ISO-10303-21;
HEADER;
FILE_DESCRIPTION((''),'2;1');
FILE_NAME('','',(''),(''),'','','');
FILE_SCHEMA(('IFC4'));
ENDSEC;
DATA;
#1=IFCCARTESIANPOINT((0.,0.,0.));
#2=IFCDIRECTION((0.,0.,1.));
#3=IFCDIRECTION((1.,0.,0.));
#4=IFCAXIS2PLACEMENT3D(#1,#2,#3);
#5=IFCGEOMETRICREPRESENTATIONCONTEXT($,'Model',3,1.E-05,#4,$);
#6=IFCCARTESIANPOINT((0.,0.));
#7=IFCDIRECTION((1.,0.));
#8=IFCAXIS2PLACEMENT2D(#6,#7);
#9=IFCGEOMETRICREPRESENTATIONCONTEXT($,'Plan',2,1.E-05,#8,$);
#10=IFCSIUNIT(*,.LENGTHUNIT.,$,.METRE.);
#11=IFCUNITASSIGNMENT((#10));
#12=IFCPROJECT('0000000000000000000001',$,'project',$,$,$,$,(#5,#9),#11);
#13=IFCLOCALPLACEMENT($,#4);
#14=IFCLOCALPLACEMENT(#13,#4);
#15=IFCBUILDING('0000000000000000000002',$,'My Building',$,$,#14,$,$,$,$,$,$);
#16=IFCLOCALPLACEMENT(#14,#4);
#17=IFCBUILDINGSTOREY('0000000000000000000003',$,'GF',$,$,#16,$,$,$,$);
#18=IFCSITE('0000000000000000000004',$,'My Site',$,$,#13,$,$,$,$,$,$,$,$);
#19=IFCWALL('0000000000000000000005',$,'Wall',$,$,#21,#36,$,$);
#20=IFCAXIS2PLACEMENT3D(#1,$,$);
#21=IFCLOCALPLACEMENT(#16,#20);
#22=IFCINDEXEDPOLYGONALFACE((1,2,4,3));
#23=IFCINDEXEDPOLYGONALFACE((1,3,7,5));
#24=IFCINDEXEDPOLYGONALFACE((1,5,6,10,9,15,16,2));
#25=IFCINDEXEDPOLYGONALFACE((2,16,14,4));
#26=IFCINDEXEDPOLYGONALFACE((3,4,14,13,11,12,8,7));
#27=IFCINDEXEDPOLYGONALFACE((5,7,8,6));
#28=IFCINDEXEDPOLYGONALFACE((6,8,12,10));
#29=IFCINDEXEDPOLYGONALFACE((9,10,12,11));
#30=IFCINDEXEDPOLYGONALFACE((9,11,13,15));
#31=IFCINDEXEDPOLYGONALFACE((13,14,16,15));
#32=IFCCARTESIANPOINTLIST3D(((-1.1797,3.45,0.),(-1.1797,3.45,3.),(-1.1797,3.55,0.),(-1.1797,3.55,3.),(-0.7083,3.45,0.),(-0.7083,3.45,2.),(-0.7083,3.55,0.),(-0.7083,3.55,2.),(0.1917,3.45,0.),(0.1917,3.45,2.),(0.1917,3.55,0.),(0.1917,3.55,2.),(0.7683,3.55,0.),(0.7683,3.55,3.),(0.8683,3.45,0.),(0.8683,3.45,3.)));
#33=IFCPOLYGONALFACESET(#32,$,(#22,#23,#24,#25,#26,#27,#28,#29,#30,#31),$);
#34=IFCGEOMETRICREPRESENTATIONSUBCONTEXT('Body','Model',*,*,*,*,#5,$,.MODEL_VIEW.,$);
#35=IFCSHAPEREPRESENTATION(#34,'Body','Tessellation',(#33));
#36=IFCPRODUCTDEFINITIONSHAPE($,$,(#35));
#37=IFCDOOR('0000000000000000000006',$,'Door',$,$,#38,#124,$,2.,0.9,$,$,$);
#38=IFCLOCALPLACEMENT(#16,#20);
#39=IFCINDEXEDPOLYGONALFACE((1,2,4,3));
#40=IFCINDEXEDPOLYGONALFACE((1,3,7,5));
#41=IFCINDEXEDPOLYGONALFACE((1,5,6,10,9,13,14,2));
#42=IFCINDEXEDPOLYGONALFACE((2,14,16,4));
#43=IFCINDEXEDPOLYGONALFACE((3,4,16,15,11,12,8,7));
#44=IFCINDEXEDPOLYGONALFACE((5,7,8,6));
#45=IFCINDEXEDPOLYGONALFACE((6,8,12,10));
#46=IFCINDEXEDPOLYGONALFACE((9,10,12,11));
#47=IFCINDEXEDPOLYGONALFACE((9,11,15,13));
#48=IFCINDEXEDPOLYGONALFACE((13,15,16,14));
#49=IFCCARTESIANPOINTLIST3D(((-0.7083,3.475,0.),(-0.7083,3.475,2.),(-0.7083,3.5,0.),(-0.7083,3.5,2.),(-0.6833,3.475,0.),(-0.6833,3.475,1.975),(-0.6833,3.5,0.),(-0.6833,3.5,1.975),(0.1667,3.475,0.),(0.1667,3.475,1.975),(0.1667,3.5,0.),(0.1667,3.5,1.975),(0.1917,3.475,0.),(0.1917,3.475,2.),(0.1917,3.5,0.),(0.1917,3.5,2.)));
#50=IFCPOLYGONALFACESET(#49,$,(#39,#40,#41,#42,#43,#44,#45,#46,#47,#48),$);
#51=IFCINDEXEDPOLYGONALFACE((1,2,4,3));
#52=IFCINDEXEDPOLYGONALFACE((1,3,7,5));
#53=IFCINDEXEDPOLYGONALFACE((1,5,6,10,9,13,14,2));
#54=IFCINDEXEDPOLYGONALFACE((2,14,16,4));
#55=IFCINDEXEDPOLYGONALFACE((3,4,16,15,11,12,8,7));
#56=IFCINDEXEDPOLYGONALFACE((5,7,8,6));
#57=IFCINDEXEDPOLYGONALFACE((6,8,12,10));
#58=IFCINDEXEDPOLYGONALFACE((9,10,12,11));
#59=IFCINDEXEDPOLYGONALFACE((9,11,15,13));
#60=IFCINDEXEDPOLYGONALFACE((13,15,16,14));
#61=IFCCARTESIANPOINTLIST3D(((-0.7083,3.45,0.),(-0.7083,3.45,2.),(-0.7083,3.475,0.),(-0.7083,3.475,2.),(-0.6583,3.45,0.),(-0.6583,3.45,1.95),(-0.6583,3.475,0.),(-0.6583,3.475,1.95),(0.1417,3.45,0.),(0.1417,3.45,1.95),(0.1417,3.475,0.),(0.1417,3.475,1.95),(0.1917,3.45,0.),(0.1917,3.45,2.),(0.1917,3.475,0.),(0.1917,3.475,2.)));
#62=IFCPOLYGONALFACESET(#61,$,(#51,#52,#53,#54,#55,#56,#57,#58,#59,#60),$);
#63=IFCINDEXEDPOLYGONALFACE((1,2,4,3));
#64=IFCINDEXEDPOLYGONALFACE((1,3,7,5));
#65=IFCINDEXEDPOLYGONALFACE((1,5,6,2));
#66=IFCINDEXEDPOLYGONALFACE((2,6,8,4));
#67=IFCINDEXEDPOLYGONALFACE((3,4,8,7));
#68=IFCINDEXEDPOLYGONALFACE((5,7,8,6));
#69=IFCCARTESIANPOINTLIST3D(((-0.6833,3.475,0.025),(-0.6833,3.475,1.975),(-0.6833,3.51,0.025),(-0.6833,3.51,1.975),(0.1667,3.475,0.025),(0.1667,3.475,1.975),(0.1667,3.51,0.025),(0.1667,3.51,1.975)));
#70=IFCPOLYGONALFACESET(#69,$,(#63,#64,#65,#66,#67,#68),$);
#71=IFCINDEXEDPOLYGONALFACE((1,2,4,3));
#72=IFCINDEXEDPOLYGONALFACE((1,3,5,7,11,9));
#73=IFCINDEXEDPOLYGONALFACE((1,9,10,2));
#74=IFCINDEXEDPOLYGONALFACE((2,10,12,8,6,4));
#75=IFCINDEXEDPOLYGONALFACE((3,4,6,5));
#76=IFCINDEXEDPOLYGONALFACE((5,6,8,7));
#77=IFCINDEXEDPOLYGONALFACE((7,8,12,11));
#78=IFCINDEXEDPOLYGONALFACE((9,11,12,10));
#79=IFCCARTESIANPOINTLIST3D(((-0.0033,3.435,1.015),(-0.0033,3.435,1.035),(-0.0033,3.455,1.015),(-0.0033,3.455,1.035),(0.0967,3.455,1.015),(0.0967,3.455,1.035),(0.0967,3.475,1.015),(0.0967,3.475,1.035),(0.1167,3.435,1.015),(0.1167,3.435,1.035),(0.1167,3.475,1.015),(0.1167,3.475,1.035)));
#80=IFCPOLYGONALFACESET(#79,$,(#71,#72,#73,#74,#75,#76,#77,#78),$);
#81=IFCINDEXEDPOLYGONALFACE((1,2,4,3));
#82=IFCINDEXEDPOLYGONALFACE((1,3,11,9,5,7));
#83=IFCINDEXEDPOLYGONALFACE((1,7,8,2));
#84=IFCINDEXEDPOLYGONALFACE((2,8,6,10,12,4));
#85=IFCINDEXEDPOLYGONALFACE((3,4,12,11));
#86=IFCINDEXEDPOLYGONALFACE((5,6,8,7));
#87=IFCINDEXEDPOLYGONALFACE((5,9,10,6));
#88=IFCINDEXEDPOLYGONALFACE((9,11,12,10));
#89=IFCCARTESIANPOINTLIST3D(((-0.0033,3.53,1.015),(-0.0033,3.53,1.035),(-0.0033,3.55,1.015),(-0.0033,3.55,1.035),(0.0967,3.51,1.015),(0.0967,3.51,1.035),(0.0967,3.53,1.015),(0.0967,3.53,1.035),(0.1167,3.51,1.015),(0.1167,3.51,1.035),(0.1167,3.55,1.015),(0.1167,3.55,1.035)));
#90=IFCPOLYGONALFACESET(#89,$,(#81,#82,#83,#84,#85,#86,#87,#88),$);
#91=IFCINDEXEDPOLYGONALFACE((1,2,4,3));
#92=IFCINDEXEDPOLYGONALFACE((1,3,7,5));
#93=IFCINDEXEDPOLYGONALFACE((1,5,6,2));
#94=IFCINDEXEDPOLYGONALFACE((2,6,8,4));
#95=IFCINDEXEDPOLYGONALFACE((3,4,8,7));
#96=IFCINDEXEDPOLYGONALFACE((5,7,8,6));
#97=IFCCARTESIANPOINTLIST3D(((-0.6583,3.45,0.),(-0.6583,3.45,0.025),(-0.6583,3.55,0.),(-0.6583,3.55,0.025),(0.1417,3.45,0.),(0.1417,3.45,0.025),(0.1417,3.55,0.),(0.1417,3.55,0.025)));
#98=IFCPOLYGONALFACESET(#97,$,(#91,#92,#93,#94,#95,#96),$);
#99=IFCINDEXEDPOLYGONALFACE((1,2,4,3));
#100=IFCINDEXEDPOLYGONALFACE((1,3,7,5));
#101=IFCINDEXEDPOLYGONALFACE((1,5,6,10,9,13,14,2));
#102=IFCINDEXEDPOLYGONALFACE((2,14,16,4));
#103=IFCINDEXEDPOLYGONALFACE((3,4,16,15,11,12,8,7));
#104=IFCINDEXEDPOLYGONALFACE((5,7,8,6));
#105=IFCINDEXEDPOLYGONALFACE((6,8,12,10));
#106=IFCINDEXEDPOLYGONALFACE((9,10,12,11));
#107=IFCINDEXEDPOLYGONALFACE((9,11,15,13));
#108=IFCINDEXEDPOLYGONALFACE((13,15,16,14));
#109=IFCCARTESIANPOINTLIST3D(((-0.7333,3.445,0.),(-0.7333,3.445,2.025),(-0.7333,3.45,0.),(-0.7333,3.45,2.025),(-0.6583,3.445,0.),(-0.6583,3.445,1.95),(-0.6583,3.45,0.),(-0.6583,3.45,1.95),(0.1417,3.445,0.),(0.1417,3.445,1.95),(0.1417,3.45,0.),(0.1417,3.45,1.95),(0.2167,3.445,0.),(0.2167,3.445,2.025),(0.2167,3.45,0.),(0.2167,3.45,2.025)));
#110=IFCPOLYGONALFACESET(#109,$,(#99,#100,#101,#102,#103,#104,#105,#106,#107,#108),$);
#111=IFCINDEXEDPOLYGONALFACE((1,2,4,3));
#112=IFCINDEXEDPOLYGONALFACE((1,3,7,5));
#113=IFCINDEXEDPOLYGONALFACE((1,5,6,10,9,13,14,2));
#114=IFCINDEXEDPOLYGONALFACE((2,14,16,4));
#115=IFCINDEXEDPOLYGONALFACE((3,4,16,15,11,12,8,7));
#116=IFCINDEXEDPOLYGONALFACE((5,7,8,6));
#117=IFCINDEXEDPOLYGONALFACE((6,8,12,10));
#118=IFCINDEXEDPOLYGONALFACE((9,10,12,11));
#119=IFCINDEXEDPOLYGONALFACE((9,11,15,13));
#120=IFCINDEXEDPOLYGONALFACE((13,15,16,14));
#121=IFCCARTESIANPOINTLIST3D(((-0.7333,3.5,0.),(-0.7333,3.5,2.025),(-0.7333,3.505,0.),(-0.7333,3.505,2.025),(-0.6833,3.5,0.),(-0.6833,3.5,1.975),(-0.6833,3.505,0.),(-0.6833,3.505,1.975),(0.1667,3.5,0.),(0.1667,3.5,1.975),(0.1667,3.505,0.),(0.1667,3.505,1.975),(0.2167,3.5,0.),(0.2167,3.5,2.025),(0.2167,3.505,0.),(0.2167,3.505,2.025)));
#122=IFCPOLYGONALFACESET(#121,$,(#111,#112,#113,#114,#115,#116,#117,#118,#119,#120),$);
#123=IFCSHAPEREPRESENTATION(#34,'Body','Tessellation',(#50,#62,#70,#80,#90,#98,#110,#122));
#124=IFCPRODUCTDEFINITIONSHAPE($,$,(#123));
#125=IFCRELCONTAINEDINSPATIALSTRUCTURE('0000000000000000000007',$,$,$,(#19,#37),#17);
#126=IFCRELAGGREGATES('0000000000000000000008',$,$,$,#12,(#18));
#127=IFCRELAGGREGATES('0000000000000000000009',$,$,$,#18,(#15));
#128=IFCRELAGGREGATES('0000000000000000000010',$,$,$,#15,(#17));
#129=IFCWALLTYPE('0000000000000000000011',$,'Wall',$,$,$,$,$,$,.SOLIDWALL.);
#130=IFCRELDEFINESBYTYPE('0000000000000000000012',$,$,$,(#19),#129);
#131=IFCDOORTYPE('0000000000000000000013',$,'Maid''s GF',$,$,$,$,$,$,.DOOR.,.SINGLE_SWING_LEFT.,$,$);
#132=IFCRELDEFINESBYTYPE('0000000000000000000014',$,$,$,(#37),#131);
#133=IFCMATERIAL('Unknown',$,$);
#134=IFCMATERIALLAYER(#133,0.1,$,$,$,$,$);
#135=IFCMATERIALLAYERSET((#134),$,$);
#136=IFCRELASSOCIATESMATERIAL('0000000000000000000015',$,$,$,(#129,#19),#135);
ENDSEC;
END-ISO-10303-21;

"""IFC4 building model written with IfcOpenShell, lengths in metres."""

from ifc_helpers import new_model, entity, si_unit, frame, origin_with_axes, origin_2d_with_axis, place, context, subcontext, project, spatial, line, indexed_curve, outline, extrude, shape, source, transform, mapped, material, layer, layer_set, layer_usage, type_object, type_shapes, element, fill, save


model = new_model("IFC4")

# Units and contexts
model_context = context("Model", 3, precision=1e-05, world=origin_with_axes())
plan_context = context("Plan", 2, precision=1e-05, world=origin_2d_with_axis())
body_context_1 = subcontext(model_context, "Body", "Model", "MODEL_VIEW")
body_context_2 = subcontext(plan_context, "Body", "Plan", "PLAN_VIEW")
ifc_project = project(units=[si_unit("LENGTHUNIT", "METRE")], contexts=[model_context, plan_context])

# Site, building, storey
site_placement = place(None, origin_with_axes())
site = spatial("IfcSite", under=ifc_project, at=site_placement, Name="My Site")
building_placement = place(site_placement, origin_with_axes())
building = spatial("IfcBuilding", under=site, at=building_placement, Name="My Building")
storey_placement = place(building_placement, origin_with_axes())
storey = spatial("IfcBuildingStorey", under=building, at=storey_placement, Name="GF")

# Shared definitions
ifc_material_1 = material(Name="Unknown")
ifc_layer = layer(ifc_material_1, 0.1)
ifc_layer_set = layer_set([ifc_layer])
wall_type = type_object("IfcWallType", Name="Wall", PredefinedType="SOLIDWALL", material=ifc_layer_set)

# Wall, opening, door
ifc_layer_usage_1 = layer_usage(ifc_layer_set, "AXIS2", "POSITIVE", 0.0)
wall_1_placement = place(storey_placement, frame((0.7683, 3.55, 0.0), z_axis=(0.0, 0.0, 1.0), x_axis=(-1.0, 0.0, 0.0)))
wall_1 = element("IfcWall", 1, at=wall_1_placement, inside=storey, type_object=wall_type, material=ifc_layer_usage_1, Name="Wall", context=body_context_1, shape_type="SweptSolid", body=[
    extrude(outline(indexed_curve([(0.0, 0.0), (-0.1, 0.1), (1.948, 0.1), (1.948, 0.0)], segments=[line(1, 2, 3, 4, 1)])), origin_with_axes(), (0.0, 0.0, 1.0), 3.0),
])
shared_shape_1 = source(origin_with_axes(), body_context_1, "Body", "SweptSolid", [
    extrude(outline(indexed_curve([(0.0, 0.0), (0.9, 0.0), (0.9, 2.0), (0.0, 2.0)], segments=[line(1, 2, 3, 4, 1)])), frame((0.0, -0.6, 0.0), z_axis=(0.0, -1.0, 0.0), x_axis=(1.0, 0.0, 0.0)), (0.0, 0.0, -1.0), 1.2),
])
opening_1_placement = place(wall_1_placement, frame((1.4766, 0.1, 0.0), z_axis=(0.0, 0.0, 1.0), x_axis=(-1.0, 0.0, 0.0)))
opening_1 = element("IfcOpeningElement", 2, at=opening_1_placement, cuts=wall_1, PredefinedType="OPENING", context=body_context_1, shape_type="MappedRepresentation", body=[
    mapped(shared_shape_1, transform((0.0, 0.0, 0.0), x_axis=(1.0, 0.0, 0.0), y_axis=(0.0, 1.0, 0.0), z_axis=(0.0, 0.0, 1.0), scale=1.0)),
])
door_type_1 = type_object("IfcDoorType", Name="Maid's GF", OperationType="SINGLE_SWING_LEFT", PredefinedType="DOOR")
shared_shape_2 = source(origin_with_axes(), body_context_1, "Body", "SweptSolid", [
    extrude(outline(indexed_curve([(0.0, 0.0), (0.0, 2.0), (0.9, 2.0), (0.9, 0.0), (0.875, 0.0), (0.875, 1.975), (0.025, 1.975), (0.025, 0.0)], segments=[line(1, 2, 3, 4, 5, 6, 7, 8, 1)])), frame((0.0, 0.025, 0.0), z_axis=(0.0, -1.0, 0.0), x_axis=(1.0, 0.0, 0.0)), (0.0, 0.0, -1.0), 0.025),
    extrude(outline(indexed_curve([(0.0, 0.0), (0.0, 2.0), (0.9, 2.0), (0.9, 0.0), (0.85, 0.0), (0.85, 1.95), (0.05, 1.95), (0.05, 0.0)], segments=[line(1, 2, 3, 4, 5, 6, 7, 8, 1)])), frame((0.0, 0.0, 0.0), z_axis=(0.0, -1.0, 0.0), x_axis=(1.0, 0.0, 0.0)), (0.0, 0.0, -1.0), 0.025),
    extrude(outline(indexed_curve([(0.0, 0.0), (0.85, 0.0), (0.85, 0.035), (0.0, 0.035)], segments=[line(1, 2, 3, 4, 1)])), frame((0.025, 0.025, 0.025), z_axis=(0.0, 0.0, 1.0), x_axis=(1.0, 0.0, 0.0)), (0.0, 0.0, 1.0), 1.95),
    extrude(outline(indexed_curve([(0.0, 0.0), (0.0, -0.04), (-0.12, -0.04), (-0.12, -0.02), (-0.02, -0.02), (-0.02, 0.0)], segments=[line(1, 2, 3, 4, 5, 6, 1)])), frame((0.825, 0.025, 1.015), z_axis=(0.0, 0.0, 1.0), x_axis=(1.0, 0.0, 0.0)), (0.0, 0.0, 1.0), 0.02),
    extrude(outline(indexed_curve([(0.0, 0.0), (0.0, 0.04), (-0.12, 0.04), (-0.12, 0.02), (-0.02, 0.02), (-0.02, 0.0)], segments=[line(1, 2, 3, 4, 5, 6, 1)])), frame((0.825, 0.06, 1.015), z_axis=(0.0, 0.0, 1.0), x_axis=(1.0, 0.0, 0.0)), (0.0, 0.0, 1.0), 0.02),
    extrude(outline(indexed_curve([(0.0, 0.0), (0.8, 0.0), (0.8, 0.1), (0.0, 0.1)], segments=[line(1, 2, 3, 4, 1)])), frame((0.05, 0.0, 0.0), z_axis=(0.0, 0.0, 1.0), x_axis=(1.0, 0.0, 0.0)), (0.0, 0.0, 1.0), 0.025),
    extrude(outline(indexed_curve([(0.0, 0.0), (0.0, 2.025), (0.95, 2.025), (0.95, 0.0), (0.875, 0.0), (0.875, 1.95), (0.075, 1.95), (0.075, 0.0)], segments=[line(1, 2, 3, 4, 5, 6, 7, 8, 1)])), frame((-0.025, -0.005, 0.0), z_axis=(0.0, -1.0, 0.0), x_axis=(1.0, 0.0, 0.0)), (0.0, 0.0, -1.0), 0.005),
    extrude(outline(indexed_curve([(0.0, 0.0), (0.0, 2.025), (0.95, 2.025), (0.95, 0.0), (0.9, 0.0), (0.9, 1.975), (0.05, 1.975), (0.05, 0.0)], segments=[line(1, 2, 3, 4, 5, 6, 7, 8, 1)])), frame((-0.025, 0.05, 0.0), z_axis=(0.0, -1.0, 0.0), x_axis=(1.0, 0.0, 0.0)), (0.0, 0.0, -1.0), 0.005),
])
shared_shape_3 = source(origin_with_axes(), body_context_2, "Body", "Curve2D", [
    entity("IfcIndexedPolyCurve", entity("IfcCartesianPointList2D", [[0.0, 0.0], [0.0, 0.05], [0.025, 0.05], [0.025, 0.025], [0.05, 0.025], [0.05, 0.0]]), [entity("IfcLineIndex", [1, 2, 3, 4, 5, 6, 1])]),
    entity("IfcIndexedPolyCurve", entity("IfcCartesianPointList2D", [[0.9, 0.0], [0.9, 0.05], [0.875, 0.05], [0.875, 0.025], [0.85, 0.025], [0.85, 0.0]]), [entity("IfcLineIndex", [1, 2, 3, 4, 5, 6, 1])]),
    entity("IfcTrimmedCurve", entity("IfcEllipse", entity("IfcAxis2Placement2D", entity("IfcCartesianPoint", [0.06, 0.05]), entity("IfcDirection", [1.0, 0.0])), 0.815, 0.85), [entity("IfcCartesianPoint", [0.875, 0.05])], [entity("IfcCartesianPoint", [0.06, 0.9])], True, "CARTESIAN"),
    entity("IfcIndexedPolyCurve", entity("IfcCartesianPointList2D", [[0.025, 0.05], [0.06, 0.05], [0.06, 0.9], [0.025, 0.9]]), [entity("IfcLineIndex", [1, 2, 3, 4, 1])]),
])
type_shapes(door_type_1, [shared_shape_2, shared_shape_3])
door_1_placement = place(opening_1_placement, frame((0.0, 0.0, 0.0), z_axis=(0.0, 0.0, 1.0), x_axis=(1.0, 0.0, 0.0)))
door_1 = element("IfcDoor", 3, at=door_1_placement, inside=storey, type_object=door_type_1, Name="Door", OverallHeight=2.0, OverallWidth=0.9, shapes=[
    shape(body_context_1, "Body", "MappedRepresentation", [mapped(shared_shape_2, transform((0.0, 0.0, 0.0), x_axis=(1.0, 0.0, 0.0), y_axis=(0.0, 1.0, 0.0), z_axis=(0.0, 0.0, 1.0), scale=1.0))]),
    shape(body_context_2, "Body", "MappedRepresentation", [mapped(shared_shape_3, transform((0.0, 0.0, 0.0), x_axis=(1.0, 0.0, 0.0), y_axis=(0.0, 1.0, 0.0), z_axis=(0.0, 0.0, 1.0), scale=1.0))]),
])
fill(opening_1, door_1)

save(model, "model.ifc")
